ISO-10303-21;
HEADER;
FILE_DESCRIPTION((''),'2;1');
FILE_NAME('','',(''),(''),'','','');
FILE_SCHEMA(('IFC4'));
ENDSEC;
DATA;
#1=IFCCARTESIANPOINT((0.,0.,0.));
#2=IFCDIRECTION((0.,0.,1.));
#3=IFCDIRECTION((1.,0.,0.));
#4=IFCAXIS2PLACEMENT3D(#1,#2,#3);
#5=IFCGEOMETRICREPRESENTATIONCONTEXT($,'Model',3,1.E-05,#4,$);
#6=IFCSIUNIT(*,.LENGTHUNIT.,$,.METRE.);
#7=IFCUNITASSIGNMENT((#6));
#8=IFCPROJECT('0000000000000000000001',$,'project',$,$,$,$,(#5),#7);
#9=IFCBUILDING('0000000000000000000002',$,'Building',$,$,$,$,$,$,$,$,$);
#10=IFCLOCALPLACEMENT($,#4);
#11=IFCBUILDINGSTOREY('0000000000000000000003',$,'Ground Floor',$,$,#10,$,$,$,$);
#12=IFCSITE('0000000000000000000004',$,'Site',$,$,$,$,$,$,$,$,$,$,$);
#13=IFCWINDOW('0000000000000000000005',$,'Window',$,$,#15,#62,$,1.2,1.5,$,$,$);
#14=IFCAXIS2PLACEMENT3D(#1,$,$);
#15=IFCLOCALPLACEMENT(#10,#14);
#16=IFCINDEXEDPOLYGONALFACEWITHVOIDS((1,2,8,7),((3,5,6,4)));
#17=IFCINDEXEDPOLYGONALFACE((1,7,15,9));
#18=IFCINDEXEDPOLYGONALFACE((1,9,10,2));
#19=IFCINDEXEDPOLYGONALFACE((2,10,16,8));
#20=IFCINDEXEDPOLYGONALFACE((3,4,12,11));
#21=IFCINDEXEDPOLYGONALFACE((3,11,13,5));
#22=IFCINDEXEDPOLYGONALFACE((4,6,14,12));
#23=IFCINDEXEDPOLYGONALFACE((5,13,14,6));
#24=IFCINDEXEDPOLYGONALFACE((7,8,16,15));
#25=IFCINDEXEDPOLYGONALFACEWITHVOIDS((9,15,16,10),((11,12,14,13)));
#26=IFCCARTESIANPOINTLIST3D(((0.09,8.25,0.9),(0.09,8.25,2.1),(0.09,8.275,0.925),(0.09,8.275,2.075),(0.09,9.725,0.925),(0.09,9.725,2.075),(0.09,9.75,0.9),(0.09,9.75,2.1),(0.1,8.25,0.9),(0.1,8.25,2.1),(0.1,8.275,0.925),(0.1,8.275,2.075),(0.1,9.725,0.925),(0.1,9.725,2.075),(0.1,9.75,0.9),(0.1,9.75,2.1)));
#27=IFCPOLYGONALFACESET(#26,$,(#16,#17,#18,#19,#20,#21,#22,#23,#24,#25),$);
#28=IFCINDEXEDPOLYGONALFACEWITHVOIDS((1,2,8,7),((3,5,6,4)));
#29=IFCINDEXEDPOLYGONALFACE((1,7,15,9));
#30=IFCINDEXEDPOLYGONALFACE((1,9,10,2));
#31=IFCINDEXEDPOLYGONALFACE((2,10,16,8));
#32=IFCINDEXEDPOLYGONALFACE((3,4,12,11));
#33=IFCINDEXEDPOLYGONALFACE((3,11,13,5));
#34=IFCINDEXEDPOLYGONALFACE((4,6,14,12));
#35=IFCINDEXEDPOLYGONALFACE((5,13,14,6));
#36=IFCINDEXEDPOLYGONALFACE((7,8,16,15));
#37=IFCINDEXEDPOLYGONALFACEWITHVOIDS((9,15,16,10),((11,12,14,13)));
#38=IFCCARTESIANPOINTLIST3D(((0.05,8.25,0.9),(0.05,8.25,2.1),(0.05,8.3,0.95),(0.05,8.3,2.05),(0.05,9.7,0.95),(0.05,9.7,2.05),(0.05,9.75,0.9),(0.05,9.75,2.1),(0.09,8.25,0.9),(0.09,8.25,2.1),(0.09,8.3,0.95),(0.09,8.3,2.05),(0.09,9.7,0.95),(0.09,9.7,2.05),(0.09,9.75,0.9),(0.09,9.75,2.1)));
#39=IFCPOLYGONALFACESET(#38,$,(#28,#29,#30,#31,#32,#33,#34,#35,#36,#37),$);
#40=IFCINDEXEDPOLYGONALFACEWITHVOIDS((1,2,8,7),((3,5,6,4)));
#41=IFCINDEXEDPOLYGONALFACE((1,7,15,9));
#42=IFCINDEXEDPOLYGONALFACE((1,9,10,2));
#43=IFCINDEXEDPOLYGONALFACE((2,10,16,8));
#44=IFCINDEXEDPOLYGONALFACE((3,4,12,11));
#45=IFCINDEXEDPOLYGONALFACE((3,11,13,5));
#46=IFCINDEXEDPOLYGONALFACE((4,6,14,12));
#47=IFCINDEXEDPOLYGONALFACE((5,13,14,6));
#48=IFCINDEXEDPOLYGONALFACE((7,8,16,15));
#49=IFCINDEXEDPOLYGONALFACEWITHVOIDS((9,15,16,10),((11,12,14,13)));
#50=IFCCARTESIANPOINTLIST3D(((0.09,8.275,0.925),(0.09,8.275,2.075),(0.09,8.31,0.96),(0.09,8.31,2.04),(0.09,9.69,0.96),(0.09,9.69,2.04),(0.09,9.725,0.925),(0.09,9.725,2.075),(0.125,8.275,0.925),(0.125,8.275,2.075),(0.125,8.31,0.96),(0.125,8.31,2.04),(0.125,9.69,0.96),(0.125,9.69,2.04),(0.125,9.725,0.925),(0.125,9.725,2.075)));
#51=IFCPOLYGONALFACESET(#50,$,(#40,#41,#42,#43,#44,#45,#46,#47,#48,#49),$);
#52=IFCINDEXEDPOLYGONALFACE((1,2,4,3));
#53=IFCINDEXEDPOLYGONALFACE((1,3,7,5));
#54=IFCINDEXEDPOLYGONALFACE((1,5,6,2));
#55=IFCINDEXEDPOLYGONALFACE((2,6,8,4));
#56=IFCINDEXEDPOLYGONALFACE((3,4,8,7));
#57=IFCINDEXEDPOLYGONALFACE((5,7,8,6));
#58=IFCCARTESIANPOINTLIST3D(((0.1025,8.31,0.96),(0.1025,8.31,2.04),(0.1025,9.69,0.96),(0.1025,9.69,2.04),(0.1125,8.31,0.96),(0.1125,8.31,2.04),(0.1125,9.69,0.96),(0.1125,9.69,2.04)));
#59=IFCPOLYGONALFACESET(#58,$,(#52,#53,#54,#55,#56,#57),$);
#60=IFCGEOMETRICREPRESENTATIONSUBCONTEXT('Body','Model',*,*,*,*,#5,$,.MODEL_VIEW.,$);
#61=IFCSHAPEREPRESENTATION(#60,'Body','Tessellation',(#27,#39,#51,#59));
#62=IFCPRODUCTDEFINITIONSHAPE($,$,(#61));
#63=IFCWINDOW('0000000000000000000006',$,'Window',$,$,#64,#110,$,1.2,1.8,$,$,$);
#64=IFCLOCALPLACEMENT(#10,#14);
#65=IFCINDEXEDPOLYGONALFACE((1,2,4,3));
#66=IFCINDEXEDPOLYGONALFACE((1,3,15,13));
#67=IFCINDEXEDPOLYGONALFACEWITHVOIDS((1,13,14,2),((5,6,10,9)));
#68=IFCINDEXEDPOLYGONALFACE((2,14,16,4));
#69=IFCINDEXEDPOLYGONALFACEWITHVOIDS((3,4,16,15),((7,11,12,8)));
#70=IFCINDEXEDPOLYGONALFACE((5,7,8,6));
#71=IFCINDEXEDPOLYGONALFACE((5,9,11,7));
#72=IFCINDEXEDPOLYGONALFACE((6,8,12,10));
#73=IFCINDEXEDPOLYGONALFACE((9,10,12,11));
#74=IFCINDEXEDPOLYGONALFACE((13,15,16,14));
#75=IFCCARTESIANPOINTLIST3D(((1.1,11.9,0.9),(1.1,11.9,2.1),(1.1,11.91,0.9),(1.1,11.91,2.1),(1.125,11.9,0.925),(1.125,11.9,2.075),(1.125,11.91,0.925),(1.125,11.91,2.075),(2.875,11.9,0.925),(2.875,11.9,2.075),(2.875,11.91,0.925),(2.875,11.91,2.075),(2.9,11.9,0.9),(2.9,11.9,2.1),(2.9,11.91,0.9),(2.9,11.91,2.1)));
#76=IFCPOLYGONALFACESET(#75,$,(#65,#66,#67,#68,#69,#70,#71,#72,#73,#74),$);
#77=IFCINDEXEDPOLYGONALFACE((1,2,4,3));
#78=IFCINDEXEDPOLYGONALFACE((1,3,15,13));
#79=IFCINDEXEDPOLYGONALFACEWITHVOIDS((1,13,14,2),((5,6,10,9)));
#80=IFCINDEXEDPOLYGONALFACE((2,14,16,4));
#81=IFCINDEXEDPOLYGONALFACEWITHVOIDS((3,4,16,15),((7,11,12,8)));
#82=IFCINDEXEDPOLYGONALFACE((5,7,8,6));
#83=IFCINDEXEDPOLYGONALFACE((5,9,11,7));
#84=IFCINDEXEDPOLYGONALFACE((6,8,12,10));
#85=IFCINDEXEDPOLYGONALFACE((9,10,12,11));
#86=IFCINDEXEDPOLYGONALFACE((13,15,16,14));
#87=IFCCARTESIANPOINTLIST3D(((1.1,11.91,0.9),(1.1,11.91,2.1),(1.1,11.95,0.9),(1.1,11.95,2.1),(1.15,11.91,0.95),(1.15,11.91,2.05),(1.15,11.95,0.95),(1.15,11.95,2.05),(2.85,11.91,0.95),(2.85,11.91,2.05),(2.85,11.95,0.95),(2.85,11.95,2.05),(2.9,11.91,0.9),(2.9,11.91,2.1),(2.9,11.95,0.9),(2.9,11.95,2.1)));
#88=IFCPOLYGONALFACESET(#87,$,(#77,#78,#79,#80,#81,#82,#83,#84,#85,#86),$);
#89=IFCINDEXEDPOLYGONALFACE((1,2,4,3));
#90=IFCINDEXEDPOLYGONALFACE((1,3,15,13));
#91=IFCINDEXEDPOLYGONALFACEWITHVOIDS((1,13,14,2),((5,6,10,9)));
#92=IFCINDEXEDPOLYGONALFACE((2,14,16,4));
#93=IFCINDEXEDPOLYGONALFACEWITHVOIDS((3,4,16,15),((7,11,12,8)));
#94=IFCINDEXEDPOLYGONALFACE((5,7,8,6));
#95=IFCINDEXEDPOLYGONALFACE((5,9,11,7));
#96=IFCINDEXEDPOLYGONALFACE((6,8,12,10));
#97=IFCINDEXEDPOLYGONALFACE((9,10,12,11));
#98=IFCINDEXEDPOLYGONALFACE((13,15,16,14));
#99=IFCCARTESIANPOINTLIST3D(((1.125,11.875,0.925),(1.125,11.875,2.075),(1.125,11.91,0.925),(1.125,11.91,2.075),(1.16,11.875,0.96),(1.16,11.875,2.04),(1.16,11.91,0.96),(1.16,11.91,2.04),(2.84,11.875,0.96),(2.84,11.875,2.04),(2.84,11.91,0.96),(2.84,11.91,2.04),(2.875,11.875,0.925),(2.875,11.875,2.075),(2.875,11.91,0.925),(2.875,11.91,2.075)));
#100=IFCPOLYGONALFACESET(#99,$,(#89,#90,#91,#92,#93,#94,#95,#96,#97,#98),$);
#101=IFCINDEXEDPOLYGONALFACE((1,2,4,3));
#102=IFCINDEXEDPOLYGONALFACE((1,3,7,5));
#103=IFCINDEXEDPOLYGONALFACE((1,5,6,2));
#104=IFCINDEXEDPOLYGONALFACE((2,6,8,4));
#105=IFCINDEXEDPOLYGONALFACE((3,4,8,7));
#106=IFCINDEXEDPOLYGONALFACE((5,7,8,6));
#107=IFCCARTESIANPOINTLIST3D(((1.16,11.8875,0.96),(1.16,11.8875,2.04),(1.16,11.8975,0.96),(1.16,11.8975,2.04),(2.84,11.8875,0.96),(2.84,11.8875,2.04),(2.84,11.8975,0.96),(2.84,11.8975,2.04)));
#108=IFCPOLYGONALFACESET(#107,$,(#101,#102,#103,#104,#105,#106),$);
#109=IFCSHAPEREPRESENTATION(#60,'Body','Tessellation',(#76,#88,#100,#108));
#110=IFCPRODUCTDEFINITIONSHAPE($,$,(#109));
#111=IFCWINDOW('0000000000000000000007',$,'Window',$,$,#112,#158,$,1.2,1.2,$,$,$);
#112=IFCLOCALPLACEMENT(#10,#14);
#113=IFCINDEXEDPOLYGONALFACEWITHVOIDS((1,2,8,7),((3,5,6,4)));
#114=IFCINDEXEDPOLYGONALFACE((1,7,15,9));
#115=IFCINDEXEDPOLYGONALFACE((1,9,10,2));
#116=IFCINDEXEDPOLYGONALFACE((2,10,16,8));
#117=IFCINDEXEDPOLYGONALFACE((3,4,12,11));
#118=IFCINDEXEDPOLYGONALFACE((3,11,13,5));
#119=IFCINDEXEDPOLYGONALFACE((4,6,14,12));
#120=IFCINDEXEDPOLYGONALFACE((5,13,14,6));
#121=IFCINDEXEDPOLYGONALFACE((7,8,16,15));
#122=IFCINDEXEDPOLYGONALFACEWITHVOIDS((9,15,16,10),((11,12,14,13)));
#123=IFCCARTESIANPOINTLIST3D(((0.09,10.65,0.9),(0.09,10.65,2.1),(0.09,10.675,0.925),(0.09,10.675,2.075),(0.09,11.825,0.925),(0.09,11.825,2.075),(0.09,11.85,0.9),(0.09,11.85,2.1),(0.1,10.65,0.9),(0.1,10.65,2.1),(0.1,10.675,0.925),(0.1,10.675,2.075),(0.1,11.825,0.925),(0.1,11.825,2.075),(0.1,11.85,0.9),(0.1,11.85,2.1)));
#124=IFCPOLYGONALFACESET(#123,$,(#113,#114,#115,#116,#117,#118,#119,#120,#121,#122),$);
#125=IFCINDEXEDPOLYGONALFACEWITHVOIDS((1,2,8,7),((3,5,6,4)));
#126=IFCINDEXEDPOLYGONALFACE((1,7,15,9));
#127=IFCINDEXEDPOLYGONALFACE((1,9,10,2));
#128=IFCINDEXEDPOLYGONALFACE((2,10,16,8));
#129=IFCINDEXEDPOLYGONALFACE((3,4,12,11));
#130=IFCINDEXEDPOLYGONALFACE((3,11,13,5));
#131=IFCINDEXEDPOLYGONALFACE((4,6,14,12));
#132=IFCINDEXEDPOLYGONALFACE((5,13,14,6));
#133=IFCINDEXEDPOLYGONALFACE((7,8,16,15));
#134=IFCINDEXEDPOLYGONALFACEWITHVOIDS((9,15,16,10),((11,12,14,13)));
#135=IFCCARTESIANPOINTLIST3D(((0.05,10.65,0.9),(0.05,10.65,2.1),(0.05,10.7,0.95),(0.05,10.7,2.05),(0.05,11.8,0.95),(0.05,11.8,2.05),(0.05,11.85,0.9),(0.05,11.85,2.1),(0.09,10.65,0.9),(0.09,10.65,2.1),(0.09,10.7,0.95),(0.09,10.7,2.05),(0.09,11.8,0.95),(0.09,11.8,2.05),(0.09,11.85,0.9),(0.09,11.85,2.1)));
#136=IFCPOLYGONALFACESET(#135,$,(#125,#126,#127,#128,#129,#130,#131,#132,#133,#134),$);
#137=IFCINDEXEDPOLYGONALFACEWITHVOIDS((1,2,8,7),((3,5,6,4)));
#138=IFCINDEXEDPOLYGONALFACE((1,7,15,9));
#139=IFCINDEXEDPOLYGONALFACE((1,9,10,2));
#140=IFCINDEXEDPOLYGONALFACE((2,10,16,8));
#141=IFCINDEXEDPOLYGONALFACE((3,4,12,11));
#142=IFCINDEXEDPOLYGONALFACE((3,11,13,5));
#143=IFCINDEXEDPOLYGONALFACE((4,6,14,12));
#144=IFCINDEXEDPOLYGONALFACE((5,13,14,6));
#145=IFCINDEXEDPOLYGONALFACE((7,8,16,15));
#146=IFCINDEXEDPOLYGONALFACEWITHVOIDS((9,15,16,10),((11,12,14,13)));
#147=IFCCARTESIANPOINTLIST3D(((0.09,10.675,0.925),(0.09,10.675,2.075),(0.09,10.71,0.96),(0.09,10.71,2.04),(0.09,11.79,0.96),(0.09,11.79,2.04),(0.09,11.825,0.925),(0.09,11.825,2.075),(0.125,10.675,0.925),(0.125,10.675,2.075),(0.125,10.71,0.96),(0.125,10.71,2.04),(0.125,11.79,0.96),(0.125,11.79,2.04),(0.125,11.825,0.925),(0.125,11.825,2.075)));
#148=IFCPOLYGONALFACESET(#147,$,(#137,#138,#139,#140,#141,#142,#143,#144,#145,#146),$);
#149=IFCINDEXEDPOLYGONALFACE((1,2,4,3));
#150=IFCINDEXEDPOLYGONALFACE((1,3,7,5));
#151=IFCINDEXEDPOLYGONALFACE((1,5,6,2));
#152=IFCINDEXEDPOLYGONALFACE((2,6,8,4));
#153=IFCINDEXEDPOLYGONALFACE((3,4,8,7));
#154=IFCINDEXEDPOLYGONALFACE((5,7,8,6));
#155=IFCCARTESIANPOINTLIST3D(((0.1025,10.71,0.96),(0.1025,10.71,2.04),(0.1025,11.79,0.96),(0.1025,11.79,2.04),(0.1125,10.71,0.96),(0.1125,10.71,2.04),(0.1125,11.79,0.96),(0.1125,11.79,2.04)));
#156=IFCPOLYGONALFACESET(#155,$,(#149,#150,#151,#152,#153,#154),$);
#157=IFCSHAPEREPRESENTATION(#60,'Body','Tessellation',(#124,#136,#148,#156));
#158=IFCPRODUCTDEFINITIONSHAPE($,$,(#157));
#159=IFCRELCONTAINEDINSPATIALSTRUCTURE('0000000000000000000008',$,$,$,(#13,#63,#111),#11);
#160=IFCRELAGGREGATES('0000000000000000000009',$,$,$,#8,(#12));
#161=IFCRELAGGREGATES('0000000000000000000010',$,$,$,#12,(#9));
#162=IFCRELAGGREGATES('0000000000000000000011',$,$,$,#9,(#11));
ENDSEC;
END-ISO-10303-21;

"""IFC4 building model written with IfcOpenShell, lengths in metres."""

from ifc_helpers import new_model, si_unit, frame, origin_with_axes, place, context, subcontext, project, spatial, line, indexed_curve, outline, extrude, element, save


model = new_model("IFC4")

# Units and contexts
model_context = context("Model", 3, precision=1e-05, world=origin_with_axes())
body_context = subcontext(model_context, "Body", "Model", "MODEL_VIEW")
ifc_project = project(units=[si_unit("LENGTHUNIT", "METRE")], contexts=[model_context])

# Site, building, storey
site = spatial("IfcSite", under=ifc_project, Name="Site")
building = spatial("IfcBuilding", under=site, Name="Building")
storey_placement = place(None, origin_with_axes())
storey = spatial("IfcBuildingStorey", under=building, at=storey_placement, Name="Ground Floor")

# Windows
window_1_placement = place(storey_placement, frame((0.0, 9.75, 0.9), z_axis=(0.0, 0.0, 1.0), x_axis=(0.0, -1.0, 0.0)))
element("IfcWindow", 1, at=window_1_placement, inside=storey, Name="Window", OverallHeight=1.2, OverallWidth=1.5, context=body_context, shape_type="SweptSolid", body=[
    extrude(outline(indexed_curve([(0.0, 0.0), (1.5, 0.0), (1.5, 1.2), (0.0, 1.2)], segments=[line(1, 2, 3, 4, 1)]), holes=[indexed_curve([(0.025, 0.025), (1.475, 0.025), (1.475, 1.175), (0.025, 1.175)], segments=[line(1, 2, 3, 4, 1)])]), frame((0.0, 0.09, 0.0), z_axis=(0.0, -1.0, 0.0), x_axis=(1.0, 0.0, 0.0)), (0.0, 0.0, -1.0), 0.01),
    extrude(outline(indexed_curve([(0.0, 0.0), (1.5, 0.0), (1.5, 1.2), (0.0, 1.2)], segments=[line(1, 2, 3, 4, 1)]), holes=[indexed_curve([(0.05, 0.05), (1.45, 0.05), (1.45, 1.15), (0.05, 1.15)], segments=[line(1, 2, 3, 4, 1)])]), frame((0.0, 0.05, 0.0), z_axis=(0.0, -1.0, 0.0), x_axis=(1.0, 0.0, 0.0)), (0.0, 0.0, -1.0), 0.04),
    extrude(outline(indexed_curve([(0.0, 0.0), (1.45, 0.0), (1.45, 1.15), (0.0, 1.15)], segments=[line(1, 2, 3, 4, 1)]), holes=[indexed_curve([(0.035, 0.035), (1.415, 0.035), (1.415, 1.115), (0.035, 1.115)], segments=[line(1, 2, 3, 4, 1)])]), frame((0.025, 0.09, 0.025), z_axis=(0.0, -1.0, 0.0), x_axis=(1.0, 0.0, 0.0)), (0.0, 0.0, -1.0), 0.035),
    extrude(outline(indexed_curve([(0.035, 0.035), (1.415, 0.035), (1.415, 1.115), (0.035, 1.115)], segments=[line(1, 2, 3, 4, 1)])), frame((0.025, 0.1025, 0.025), z_axis=(0.0, -1.0, 0.0), x_axis=(1.0, 0.0, 0.0)), (0.0, 0.0, -1.0), 0.01),
])
window_2_placement = place(storey_placement, frame((2.9, 12.0, 0.9), z_axis=(0.0, 0.0, 1.0), x_axis=(-1.0, 0.0, 0.0)))
element("IfcWindow", 2, at=window_2_placement, inside=storey, Name="Window", OverallHeight=1.2, OverallWidth=1.8, context=body_context, shape_type="SweptSolid", body=[
    extrude(outline(indexed_curve([(0.0, 0.0), (1.8, 0.0), (1.8, 1.2), (0.0, 1.2)], segments=[line(1, 2, 3, 4, 1)]), holes=[indexed_curve([(0.025, 0.025), (1.775, 0.025), (1.775, 1.175), (0.025, 1.175)], segments=[line(1, 2, 3, 4, 1)])]), frame((0.0, 0.09, 0.0), z_axis=(0.0, -1.0, 0.0), x_axis=(1.0, 0.0, 0.0)), (0.0, 0.0, -1.0), 0.01),
    extrude(outline(indexed_curve([(0.0, 0.0), (1.8, 0.0), (1.8, 1.2), (0.0, 1.2)], segments=[line(1, 2, 3, 4, 1)]), holes=[indexed_curve([(0.05, 0.05), (1.75, 0.05), (1.75, 1.15), (0.05, 1.15)], segments=[line(1, 2, 3, 4, 1)])]), frame((0.0, 0.05, 0.0), z_axis=(0.0, -1.0, 0.0), x_axis=(1.0, 0.0, 0.0)), (0.0, 0.0, -1.0), 0.04),
    extrude(outline(indexed_curve([(0.0, 0.0), (1.75, 0.0), (1.75, 1.15), (0.0, 1.15)], segments=[line(1, 2, 3, 4, 1)]), holes=[indexed_curve([(0.035, 0.035), (1.715, 0.035), (1.715, 1.115), (0.035, 1.115)], segments=[line(1, 2, 3, 4, 1)])]), frame((0.025, 0.09, 0.025), z_axis=(0.0, -1.0, 0.0), x_axis=(1.0, 0.0, 0.0)), (0.0, 0.0, -1.0), 0.035),
    extrude(outline(indexed_curve([(0.035, 0.035), (1.715, 0.035), (1.715, 1.115), (0.035, 1.115)], segments=[line(1, 2, 3, 4, 1)])), frame((0.025, 0.1025, 0.025), z_axis=(0.0, -1.0, 0.0), x_axis=(1.0, 0.0, 0.0)), (0.0, 0.0, -1.0), 0.01),
])
window_3_placement = place(storey_placement, frame((0.0, 11.85, 0.9), z_axis=(0.0, 0.0, 1.0), x_axis=(0.0, -1.0, 0.0)))
element("IfcWindow", 3, at=window_3_placement, inside=storey, Name="Window", OverallHeight=1.2, OverallWidth=1.2, context=body_context, shape_type="SweptSolid", body=[
    extrude(outline(indexed_curve([(0.0, 0.0), (1.2, 0.0), (1.2, 1.2), (0.0, 1.2)], segments=[line(1, 2, 3, 4, 1)]), holes=[indexed_curve([(0.025, 0.025), (1.175, 0.025), (1.175, 1.175), (0.025, 1.175)], segments=[line(1, 2, 3, 4, 1)])]), frame((0.0, 0.09, 0.0), z_axis=(0.0, -1.0, 0.0), x_axis=(1.0, 0.0, 0.0)), (0.0, 0.0, -1.0), 0.01),
    extrude(outline(indexed_curve([(0.0, 0.0), (1.2, 0.0), (1.2, 1.2), (0.0, 1.2)], segments=[line(1, 2, 3, 4, 1)]), holes=[indexed_curve([(0.05, 0.05), (1.15, 0.05), (1.15, 1.15), (0.05, 1.15)], segments=[line(1, 2, 3, 4, 1)])]), frame((0.0, 0.05, 0.0), z_axis=(0.0, -1.0, 0.0), x_axis=(1.0, 0.0, 0.0)), (0.0, 0.0, -1.0), 0.04),
    extrude(outline(indexed_curve([(0.0, 0.0), (1.15, 0.0), (1.15, 1.15), (0.0, 1.15)], segments=[line(1, 2, 3, 4, 1)]), holes=[indexed_curve([(0.035, 0.035), (1.115, 0.035), (1.115, 1.115), (0.035, 1.115)], segments=[line(1, 2, 3, 4, 1)])]), frame((0.025, 0.09, 0.025), z_axis=(0.0, -1.0, 0.0), x_axis=(1.0, 0.0, 0.0)), (0.0, 0.0, -1.0), 0.035),
    extrude(outline(indexed_curve([(0.035, 0.035), (1.115, 0.035), (1.115, 1.115), (0.035, 1.115)], segments=[line(1, 2, 3, 4, 1)])), frame((0.025, 0.1025, 0.025), z_axis=(0.0, -1.0, 0.0), x_axis=(1.0, 0.0, 0.0)), (0.0, 0.0, -1.0), 0.01),
])

save(model, "model.ifc")
